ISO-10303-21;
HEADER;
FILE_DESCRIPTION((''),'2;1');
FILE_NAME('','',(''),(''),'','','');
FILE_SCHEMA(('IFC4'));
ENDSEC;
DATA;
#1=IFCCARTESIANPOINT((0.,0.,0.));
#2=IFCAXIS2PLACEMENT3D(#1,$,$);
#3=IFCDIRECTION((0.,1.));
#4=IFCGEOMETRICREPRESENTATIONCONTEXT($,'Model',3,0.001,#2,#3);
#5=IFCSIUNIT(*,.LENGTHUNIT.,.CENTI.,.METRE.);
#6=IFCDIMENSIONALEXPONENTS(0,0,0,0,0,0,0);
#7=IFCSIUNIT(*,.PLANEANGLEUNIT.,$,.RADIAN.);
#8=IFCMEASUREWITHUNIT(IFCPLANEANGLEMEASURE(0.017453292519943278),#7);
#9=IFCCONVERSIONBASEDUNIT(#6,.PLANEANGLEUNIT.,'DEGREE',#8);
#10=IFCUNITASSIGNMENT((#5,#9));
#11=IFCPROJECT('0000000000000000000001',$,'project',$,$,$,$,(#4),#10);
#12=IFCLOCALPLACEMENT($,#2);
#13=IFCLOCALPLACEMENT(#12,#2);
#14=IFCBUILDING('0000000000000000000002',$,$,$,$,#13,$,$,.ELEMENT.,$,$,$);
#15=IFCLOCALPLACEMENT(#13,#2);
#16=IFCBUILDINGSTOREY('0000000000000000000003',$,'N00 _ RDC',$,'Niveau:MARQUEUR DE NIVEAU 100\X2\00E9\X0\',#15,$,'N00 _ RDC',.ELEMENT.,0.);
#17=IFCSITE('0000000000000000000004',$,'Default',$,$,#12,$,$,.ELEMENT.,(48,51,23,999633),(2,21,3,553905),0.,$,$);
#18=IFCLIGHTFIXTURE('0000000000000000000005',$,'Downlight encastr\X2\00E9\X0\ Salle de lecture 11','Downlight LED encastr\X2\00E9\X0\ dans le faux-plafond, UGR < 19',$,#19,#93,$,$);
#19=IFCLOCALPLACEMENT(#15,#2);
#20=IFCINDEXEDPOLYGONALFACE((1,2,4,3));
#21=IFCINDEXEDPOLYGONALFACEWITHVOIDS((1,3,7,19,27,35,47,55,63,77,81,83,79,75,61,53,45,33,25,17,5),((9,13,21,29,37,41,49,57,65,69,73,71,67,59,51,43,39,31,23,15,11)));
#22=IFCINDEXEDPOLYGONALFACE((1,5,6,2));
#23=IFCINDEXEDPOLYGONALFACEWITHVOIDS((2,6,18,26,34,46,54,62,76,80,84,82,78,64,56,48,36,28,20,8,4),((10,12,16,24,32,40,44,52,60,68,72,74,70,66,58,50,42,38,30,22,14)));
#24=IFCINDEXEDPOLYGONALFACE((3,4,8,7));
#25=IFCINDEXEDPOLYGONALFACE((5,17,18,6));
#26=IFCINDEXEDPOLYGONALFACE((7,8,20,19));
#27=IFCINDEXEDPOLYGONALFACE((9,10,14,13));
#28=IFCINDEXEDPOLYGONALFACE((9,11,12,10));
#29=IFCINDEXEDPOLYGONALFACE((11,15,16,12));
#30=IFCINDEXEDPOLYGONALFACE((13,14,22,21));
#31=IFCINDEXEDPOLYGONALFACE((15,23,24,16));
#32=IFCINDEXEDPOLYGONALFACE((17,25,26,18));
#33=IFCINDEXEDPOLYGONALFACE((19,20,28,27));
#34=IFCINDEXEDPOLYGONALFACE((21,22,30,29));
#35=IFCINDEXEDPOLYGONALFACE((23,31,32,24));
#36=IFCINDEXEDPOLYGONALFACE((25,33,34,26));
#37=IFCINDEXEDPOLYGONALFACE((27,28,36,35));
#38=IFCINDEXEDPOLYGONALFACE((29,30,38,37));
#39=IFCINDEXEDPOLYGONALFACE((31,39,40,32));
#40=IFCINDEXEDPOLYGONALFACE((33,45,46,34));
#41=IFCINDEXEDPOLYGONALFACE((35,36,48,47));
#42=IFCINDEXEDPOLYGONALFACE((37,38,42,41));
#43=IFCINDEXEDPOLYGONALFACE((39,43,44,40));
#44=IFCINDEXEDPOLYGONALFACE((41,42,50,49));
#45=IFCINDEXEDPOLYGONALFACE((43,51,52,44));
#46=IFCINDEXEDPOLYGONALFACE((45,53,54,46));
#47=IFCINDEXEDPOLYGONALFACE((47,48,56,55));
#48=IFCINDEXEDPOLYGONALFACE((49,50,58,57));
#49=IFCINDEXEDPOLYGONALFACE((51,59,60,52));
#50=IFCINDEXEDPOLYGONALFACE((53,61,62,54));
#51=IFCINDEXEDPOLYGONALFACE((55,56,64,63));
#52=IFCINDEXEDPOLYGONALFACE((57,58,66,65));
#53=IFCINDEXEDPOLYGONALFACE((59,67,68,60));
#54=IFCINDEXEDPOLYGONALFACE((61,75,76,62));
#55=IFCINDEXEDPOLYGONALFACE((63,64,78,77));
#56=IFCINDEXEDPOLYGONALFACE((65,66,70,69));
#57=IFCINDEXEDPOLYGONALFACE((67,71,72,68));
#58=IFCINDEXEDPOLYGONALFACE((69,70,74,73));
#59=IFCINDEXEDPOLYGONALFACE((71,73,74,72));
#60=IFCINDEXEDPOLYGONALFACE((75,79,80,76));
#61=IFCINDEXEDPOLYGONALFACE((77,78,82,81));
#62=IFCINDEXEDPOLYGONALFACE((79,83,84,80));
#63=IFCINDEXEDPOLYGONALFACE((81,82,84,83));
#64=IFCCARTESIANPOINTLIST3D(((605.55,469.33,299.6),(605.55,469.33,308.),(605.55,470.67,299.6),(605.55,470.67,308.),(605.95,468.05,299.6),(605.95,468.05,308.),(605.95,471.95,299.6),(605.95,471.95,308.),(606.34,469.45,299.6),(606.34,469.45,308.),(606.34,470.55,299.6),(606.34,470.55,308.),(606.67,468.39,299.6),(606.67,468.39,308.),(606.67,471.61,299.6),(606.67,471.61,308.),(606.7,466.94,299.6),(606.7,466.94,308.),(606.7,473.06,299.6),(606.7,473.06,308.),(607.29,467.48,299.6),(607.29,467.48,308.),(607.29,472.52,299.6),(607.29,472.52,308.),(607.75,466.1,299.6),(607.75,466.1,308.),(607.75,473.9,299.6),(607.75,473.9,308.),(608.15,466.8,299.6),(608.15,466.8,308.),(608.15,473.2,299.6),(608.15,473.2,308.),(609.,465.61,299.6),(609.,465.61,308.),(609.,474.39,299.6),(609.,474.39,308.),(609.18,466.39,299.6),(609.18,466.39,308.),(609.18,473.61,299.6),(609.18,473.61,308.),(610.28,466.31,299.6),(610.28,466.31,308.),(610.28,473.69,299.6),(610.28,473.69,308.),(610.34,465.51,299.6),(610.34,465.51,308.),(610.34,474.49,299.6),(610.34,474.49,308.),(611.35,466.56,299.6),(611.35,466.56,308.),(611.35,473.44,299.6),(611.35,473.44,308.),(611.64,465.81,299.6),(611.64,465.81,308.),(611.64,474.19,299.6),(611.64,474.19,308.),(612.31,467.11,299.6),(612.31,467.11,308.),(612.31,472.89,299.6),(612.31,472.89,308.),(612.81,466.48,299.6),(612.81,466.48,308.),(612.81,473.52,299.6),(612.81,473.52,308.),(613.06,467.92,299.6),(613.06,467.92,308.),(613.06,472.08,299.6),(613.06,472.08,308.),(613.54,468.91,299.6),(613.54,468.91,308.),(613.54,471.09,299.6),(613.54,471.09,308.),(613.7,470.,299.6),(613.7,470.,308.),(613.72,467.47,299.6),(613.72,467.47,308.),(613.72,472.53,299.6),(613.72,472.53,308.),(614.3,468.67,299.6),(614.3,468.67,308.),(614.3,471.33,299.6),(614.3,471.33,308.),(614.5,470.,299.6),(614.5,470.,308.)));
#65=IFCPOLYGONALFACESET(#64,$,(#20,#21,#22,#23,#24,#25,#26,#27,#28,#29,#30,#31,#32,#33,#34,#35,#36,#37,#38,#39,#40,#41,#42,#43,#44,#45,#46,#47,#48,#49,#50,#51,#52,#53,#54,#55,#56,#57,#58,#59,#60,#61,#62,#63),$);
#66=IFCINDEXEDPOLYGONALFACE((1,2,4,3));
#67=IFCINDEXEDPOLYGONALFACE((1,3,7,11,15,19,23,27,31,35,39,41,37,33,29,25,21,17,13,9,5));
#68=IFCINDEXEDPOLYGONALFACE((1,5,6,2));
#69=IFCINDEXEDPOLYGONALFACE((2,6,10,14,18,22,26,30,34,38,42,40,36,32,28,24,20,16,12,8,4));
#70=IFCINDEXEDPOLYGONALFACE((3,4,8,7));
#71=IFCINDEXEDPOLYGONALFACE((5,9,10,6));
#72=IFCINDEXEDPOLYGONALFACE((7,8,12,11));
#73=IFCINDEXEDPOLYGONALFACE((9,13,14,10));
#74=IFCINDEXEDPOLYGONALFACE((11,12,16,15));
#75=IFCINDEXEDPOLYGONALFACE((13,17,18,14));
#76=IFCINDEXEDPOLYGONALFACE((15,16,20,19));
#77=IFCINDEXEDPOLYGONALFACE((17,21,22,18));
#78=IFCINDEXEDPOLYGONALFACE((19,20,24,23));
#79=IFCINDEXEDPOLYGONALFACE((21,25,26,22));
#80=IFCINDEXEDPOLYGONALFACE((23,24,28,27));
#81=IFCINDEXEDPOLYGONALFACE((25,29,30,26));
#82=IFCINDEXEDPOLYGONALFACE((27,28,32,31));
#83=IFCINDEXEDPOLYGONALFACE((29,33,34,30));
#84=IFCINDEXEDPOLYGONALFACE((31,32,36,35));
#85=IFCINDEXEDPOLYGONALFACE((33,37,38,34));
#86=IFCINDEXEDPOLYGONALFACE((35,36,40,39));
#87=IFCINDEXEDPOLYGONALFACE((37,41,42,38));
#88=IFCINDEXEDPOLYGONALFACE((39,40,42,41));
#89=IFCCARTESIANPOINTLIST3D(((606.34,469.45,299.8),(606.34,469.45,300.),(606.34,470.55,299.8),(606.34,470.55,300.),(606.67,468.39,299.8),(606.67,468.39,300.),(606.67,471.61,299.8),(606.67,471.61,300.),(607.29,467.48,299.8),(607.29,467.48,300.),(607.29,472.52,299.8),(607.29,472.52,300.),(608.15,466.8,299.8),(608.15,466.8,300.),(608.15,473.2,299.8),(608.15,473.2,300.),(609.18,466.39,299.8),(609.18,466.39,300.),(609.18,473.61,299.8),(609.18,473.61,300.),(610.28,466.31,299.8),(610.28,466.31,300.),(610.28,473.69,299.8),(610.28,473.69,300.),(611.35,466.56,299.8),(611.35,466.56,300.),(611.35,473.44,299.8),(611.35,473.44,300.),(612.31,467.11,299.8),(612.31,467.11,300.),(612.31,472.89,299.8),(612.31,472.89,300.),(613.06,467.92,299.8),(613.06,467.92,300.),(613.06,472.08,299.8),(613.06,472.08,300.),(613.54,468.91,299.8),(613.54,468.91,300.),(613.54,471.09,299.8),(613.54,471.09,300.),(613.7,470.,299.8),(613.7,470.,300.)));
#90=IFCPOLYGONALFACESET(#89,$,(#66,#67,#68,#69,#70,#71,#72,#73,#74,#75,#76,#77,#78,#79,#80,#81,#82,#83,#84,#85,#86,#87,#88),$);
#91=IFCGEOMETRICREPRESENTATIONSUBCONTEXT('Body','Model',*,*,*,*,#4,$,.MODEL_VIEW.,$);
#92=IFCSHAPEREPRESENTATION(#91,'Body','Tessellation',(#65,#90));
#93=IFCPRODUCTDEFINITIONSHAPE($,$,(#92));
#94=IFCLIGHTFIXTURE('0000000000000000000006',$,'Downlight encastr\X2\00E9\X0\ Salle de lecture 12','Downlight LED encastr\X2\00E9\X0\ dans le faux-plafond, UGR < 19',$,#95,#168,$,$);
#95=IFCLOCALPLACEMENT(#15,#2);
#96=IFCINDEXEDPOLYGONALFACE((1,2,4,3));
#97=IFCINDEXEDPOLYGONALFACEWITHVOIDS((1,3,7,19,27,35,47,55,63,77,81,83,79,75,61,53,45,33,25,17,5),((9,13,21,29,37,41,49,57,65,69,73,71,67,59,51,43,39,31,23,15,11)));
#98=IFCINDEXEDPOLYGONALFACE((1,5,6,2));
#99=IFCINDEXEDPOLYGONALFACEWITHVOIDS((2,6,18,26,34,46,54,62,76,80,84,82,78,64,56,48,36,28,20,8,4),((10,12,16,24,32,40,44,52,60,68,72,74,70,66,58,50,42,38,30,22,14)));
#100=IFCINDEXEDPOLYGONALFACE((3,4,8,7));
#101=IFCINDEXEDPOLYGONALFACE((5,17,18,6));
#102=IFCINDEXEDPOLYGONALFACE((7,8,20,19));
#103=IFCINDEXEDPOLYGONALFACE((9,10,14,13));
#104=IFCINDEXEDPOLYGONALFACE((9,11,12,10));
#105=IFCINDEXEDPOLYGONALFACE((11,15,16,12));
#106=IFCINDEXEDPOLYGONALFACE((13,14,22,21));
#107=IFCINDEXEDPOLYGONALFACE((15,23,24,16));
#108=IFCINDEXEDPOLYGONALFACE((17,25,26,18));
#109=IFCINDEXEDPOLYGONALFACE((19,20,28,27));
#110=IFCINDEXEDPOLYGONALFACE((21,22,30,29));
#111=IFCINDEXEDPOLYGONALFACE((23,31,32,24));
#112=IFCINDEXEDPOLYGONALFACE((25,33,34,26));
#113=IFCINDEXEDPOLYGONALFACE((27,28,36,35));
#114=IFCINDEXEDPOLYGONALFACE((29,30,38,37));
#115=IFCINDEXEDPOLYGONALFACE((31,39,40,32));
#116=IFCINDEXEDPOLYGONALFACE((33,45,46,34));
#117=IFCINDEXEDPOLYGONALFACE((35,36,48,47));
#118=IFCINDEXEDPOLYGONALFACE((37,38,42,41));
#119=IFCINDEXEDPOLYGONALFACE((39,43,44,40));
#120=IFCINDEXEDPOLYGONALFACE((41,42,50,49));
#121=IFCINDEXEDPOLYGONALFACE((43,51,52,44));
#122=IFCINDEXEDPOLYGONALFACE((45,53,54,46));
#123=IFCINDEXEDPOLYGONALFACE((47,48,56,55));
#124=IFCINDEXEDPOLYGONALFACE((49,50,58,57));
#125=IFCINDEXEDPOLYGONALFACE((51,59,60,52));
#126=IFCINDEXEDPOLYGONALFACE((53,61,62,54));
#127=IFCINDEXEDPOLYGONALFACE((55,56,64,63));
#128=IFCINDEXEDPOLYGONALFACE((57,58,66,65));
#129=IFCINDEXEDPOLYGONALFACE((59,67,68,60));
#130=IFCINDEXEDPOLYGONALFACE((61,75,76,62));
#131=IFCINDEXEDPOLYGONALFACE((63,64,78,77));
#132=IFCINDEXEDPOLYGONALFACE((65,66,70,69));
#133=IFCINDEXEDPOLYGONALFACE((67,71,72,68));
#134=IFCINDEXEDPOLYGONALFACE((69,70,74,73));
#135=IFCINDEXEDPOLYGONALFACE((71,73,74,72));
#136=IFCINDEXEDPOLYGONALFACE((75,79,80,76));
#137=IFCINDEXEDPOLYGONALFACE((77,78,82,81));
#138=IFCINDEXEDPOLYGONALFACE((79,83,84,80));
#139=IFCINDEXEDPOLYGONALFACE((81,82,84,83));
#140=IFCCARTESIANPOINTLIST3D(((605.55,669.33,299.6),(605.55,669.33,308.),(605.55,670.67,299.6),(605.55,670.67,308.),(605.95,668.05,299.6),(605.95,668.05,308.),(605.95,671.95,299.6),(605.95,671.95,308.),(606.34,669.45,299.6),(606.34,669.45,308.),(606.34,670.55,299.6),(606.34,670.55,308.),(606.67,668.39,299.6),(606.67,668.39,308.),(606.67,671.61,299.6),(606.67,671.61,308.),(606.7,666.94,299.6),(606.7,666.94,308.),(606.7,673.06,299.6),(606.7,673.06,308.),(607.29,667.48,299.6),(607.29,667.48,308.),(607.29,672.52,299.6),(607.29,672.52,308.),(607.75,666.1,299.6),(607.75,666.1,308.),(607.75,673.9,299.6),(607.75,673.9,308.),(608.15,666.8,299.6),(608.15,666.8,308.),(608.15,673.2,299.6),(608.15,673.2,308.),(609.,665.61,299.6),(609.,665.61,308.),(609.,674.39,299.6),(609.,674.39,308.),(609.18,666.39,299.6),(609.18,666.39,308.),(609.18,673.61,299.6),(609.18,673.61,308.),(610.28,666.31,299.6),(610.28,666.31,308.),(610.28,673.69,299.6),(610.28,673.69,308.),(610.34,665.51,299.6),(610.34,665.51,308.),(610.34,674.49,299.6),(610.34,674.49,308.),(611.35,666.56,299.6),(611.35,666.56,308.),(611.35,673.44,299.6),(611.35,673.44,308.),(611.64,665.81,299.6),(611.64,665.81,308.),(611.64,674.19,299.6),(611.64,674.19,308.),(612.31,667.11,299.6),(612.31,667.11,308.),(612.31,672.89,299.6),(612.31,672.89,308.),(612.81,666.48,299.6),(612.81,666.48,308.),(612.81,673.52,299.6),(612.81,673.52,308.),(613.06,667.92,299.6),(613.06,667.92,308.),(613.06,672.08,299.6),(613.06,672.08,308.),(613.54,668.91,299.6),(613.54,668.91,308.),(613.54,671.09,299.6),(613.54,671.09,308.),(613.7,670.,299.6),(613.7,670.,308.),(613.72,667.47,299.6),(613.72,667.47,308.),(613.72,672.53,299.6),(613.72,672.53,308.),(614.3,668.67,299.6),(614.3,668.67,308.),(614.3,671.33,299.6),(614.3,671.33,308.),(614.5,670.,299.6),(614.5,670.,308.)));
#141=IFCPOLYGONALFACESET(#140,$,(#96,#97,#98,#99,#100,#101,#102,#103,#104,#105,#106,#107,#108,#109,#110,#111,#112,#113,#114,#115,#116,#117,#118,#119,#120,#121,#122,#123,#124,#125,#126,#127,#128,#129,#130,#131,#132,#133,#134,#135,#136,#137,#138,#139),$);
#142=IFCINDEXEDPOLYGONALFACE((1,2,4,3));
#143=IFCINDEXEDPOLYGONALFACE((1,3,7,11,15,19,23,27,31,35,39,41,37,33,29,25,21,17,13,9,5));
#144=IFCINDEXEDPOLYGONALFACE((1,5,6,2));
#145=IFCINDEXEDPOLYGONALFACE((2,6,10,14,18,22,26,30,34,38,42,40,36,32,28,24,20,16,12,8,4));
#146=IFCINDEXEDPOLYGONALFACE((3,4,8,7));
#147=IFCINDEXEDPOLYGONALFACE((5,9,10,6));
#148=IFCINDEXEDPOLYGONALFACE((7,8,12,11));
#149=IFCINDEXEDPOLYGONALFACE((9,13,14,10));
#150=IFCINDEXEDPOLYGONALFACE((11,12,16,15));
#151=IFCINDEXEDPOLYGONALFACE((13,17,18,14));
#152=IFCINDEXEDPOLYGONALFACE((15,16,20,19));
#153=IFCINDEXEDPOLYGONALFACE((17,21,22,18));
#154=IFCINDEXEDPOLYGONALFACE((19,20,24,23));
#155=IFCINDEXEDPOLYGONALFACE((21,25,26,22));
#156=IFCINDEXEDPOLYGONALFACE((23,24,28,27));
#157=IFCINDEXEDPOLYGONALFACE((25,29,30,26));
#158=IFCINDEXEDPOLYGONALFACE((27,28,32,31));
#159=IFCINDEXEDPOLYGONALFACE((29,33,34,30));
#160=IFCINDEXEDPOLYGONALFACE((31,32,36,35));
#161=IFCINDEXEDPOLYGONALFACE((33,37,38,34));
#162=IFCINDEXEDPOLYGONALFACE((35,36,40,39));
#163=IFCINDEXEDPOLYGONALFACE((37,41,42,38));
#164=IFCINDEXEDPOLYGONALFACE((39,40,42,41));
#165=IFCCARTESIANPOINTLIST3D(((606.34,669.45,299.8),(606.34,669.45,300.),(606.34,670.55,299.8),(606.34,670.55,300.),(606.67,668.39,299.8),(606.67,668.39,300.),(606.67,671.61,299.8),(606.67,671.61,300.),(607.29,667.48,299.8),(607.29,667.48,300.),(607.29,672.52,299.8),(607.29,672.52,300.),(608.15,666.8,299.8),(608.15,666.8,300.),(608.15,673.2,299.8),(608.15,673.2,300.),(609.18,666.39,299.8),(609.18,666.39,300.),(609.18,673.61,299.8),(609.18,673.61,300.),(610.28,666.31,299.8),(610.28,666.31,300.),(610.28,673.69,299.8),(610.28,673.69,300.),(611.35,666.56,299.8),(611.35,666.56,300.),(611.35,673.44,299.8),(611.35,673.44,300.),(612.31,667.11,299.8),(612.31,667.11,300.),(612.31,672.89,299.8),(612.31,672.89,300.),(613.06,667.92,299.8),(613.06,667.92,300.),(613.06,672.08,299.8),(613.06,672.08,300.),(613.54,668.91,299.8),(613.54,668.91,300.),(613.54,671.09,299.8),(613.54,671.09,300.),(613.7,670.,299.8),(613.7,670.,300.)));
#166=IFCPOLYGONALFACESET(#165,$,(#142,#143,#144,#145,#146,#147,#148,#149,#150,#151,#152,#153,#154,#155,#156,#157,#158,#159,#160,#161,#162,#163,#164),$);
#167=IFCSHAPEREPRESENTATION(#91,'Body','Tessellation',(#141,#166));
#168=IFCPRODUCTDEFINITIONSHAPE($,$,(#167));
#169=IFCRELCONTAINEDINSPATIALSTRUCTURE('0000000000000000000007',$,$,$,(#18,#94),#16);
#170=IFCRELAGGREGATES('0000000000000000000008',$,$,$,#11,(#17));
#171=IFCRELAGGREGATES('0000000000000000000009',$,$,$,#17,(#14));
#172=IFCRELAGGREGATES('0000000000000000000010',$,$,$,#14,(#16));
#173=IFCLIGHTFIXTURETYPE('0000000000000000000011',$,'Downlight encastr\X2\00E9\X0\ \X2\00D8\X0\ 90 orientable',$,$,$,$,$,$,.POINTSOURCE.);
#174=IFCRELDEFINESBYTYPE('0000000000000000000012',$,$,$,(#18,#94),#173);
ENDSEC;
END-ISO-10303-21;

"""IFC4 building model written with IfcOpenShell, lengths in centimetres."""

from ifc_helpers import new_model, entity, si_unit, converted_unit, direction, frame, frame_2d, origin, origin_with_axes, place, context, subcontext, project, spatial, circle, hollow_circle, extrude, type_object, element, save


model = new_model("IFC4")

# Units and contexts
model_context = context("Model", 3, precision=0.001, world=origin(), true_north=direction((0.0, 1.0)))
body_context = subcontext(model_context, "Body", "Model", "MODEL_VIEW")
ifc_project = project(units=[si_unit("LENGTHUNIT", "METRE", prefix="CENTI"), converted_unit("PLANEANGLEUNIT", "DEGREE", entity("IfcPlaneAngleMeasure", 0.017453292519943278), si_unit("PLANEANGLEUNIT", "RADIAN"), dimensions=[0, 0, 0, 0, 0, 0, 0])], contexts=[model_context])

# Site, building, storey
site_placement = place(None, origin())
site = spatial("IfcSite", under=ifc_project, at=site_placement, Name="Default", CompositionType="ELEMENT", RefLatitude=(48, 51, 23, 999633), RefLongitude=(2, 21, 3, 553905), RefElevation=0.0)
building_placement = place(site_placement, origin())
building = spatial("IfcBuilding", under=site, at=building_placement, CompositionType="ELEMENT")
storey_placement = place(building_placement, origin())
storey = spatial("IfcBuildingStorey", under=building, at=storey_placement, Name="N00 _ RDC", ObjectType="Niveau:MARQUEUR DE NIVEAU 100é", LongName="N00 _ RDC", CompositionType="ELEMENT", Elevation=0.0)

# Light fixtures
light_fixture_type_1 = type_object("IfcLightFixtureType", Name="Downlight encastré Ø 90 orientable", PredefinedType="POINTSOURCE")
light_fixture_1_placement = place(storey_placement, origin_with_axes())
element("IfcLightFixture", 1, at=light_fixture_1_placement, inside=storey, type_object=light_fixture_type_1, Name="Downlight encastré Salle de lecture 11", Description="Downlight LED encastré dans le faux-plafond, UGR < 19", context=body_context, shape_type="SweptSolid", body=[
    extrude(hollow_circle(Radius=4.5, WallThickness=0.8, at=frame_2d((610.0, 470.0))), frame((0.0, 0.0, 299.6)), (0.0, 0.0, 1.0), 8.4),
    extrude(circle(Radius=3.7, at=frame_2d((610.0, 470.0))), frame((0.0, 0.0, 299.8)), (0.0, 0.0, 1.0), 0.2),
])
light_fixture_2_placement = place(storey_placement, origin_with_axes())
element("IfcLightFixture", 2, at=light_fixture_2_placement, inside=storey, type_object=light_fixture_type_1, Name="Downlight encastré Salle de lecture 12", Description="Downlight LED encastré dans le faux-plafond, UGR < 19", context=body_context, shape_type="SweptSolid", body=[
    extrude(hollow_circle(Radius=4.5, WallThickness=0.8, at=frame_2d((610.0, 670.0))), frame((0.0, 0.0, 299.6)), (0.0, 0.0, 1.0), 8.4),
    extrude(circle(Radius=3.7, at=frame_2d((610.0, 670.0))), frame((0.0, 0.0, 299.8)), (0.0, 0.0, 1.0), 0.2),
])

save(model, "model.ifc")
